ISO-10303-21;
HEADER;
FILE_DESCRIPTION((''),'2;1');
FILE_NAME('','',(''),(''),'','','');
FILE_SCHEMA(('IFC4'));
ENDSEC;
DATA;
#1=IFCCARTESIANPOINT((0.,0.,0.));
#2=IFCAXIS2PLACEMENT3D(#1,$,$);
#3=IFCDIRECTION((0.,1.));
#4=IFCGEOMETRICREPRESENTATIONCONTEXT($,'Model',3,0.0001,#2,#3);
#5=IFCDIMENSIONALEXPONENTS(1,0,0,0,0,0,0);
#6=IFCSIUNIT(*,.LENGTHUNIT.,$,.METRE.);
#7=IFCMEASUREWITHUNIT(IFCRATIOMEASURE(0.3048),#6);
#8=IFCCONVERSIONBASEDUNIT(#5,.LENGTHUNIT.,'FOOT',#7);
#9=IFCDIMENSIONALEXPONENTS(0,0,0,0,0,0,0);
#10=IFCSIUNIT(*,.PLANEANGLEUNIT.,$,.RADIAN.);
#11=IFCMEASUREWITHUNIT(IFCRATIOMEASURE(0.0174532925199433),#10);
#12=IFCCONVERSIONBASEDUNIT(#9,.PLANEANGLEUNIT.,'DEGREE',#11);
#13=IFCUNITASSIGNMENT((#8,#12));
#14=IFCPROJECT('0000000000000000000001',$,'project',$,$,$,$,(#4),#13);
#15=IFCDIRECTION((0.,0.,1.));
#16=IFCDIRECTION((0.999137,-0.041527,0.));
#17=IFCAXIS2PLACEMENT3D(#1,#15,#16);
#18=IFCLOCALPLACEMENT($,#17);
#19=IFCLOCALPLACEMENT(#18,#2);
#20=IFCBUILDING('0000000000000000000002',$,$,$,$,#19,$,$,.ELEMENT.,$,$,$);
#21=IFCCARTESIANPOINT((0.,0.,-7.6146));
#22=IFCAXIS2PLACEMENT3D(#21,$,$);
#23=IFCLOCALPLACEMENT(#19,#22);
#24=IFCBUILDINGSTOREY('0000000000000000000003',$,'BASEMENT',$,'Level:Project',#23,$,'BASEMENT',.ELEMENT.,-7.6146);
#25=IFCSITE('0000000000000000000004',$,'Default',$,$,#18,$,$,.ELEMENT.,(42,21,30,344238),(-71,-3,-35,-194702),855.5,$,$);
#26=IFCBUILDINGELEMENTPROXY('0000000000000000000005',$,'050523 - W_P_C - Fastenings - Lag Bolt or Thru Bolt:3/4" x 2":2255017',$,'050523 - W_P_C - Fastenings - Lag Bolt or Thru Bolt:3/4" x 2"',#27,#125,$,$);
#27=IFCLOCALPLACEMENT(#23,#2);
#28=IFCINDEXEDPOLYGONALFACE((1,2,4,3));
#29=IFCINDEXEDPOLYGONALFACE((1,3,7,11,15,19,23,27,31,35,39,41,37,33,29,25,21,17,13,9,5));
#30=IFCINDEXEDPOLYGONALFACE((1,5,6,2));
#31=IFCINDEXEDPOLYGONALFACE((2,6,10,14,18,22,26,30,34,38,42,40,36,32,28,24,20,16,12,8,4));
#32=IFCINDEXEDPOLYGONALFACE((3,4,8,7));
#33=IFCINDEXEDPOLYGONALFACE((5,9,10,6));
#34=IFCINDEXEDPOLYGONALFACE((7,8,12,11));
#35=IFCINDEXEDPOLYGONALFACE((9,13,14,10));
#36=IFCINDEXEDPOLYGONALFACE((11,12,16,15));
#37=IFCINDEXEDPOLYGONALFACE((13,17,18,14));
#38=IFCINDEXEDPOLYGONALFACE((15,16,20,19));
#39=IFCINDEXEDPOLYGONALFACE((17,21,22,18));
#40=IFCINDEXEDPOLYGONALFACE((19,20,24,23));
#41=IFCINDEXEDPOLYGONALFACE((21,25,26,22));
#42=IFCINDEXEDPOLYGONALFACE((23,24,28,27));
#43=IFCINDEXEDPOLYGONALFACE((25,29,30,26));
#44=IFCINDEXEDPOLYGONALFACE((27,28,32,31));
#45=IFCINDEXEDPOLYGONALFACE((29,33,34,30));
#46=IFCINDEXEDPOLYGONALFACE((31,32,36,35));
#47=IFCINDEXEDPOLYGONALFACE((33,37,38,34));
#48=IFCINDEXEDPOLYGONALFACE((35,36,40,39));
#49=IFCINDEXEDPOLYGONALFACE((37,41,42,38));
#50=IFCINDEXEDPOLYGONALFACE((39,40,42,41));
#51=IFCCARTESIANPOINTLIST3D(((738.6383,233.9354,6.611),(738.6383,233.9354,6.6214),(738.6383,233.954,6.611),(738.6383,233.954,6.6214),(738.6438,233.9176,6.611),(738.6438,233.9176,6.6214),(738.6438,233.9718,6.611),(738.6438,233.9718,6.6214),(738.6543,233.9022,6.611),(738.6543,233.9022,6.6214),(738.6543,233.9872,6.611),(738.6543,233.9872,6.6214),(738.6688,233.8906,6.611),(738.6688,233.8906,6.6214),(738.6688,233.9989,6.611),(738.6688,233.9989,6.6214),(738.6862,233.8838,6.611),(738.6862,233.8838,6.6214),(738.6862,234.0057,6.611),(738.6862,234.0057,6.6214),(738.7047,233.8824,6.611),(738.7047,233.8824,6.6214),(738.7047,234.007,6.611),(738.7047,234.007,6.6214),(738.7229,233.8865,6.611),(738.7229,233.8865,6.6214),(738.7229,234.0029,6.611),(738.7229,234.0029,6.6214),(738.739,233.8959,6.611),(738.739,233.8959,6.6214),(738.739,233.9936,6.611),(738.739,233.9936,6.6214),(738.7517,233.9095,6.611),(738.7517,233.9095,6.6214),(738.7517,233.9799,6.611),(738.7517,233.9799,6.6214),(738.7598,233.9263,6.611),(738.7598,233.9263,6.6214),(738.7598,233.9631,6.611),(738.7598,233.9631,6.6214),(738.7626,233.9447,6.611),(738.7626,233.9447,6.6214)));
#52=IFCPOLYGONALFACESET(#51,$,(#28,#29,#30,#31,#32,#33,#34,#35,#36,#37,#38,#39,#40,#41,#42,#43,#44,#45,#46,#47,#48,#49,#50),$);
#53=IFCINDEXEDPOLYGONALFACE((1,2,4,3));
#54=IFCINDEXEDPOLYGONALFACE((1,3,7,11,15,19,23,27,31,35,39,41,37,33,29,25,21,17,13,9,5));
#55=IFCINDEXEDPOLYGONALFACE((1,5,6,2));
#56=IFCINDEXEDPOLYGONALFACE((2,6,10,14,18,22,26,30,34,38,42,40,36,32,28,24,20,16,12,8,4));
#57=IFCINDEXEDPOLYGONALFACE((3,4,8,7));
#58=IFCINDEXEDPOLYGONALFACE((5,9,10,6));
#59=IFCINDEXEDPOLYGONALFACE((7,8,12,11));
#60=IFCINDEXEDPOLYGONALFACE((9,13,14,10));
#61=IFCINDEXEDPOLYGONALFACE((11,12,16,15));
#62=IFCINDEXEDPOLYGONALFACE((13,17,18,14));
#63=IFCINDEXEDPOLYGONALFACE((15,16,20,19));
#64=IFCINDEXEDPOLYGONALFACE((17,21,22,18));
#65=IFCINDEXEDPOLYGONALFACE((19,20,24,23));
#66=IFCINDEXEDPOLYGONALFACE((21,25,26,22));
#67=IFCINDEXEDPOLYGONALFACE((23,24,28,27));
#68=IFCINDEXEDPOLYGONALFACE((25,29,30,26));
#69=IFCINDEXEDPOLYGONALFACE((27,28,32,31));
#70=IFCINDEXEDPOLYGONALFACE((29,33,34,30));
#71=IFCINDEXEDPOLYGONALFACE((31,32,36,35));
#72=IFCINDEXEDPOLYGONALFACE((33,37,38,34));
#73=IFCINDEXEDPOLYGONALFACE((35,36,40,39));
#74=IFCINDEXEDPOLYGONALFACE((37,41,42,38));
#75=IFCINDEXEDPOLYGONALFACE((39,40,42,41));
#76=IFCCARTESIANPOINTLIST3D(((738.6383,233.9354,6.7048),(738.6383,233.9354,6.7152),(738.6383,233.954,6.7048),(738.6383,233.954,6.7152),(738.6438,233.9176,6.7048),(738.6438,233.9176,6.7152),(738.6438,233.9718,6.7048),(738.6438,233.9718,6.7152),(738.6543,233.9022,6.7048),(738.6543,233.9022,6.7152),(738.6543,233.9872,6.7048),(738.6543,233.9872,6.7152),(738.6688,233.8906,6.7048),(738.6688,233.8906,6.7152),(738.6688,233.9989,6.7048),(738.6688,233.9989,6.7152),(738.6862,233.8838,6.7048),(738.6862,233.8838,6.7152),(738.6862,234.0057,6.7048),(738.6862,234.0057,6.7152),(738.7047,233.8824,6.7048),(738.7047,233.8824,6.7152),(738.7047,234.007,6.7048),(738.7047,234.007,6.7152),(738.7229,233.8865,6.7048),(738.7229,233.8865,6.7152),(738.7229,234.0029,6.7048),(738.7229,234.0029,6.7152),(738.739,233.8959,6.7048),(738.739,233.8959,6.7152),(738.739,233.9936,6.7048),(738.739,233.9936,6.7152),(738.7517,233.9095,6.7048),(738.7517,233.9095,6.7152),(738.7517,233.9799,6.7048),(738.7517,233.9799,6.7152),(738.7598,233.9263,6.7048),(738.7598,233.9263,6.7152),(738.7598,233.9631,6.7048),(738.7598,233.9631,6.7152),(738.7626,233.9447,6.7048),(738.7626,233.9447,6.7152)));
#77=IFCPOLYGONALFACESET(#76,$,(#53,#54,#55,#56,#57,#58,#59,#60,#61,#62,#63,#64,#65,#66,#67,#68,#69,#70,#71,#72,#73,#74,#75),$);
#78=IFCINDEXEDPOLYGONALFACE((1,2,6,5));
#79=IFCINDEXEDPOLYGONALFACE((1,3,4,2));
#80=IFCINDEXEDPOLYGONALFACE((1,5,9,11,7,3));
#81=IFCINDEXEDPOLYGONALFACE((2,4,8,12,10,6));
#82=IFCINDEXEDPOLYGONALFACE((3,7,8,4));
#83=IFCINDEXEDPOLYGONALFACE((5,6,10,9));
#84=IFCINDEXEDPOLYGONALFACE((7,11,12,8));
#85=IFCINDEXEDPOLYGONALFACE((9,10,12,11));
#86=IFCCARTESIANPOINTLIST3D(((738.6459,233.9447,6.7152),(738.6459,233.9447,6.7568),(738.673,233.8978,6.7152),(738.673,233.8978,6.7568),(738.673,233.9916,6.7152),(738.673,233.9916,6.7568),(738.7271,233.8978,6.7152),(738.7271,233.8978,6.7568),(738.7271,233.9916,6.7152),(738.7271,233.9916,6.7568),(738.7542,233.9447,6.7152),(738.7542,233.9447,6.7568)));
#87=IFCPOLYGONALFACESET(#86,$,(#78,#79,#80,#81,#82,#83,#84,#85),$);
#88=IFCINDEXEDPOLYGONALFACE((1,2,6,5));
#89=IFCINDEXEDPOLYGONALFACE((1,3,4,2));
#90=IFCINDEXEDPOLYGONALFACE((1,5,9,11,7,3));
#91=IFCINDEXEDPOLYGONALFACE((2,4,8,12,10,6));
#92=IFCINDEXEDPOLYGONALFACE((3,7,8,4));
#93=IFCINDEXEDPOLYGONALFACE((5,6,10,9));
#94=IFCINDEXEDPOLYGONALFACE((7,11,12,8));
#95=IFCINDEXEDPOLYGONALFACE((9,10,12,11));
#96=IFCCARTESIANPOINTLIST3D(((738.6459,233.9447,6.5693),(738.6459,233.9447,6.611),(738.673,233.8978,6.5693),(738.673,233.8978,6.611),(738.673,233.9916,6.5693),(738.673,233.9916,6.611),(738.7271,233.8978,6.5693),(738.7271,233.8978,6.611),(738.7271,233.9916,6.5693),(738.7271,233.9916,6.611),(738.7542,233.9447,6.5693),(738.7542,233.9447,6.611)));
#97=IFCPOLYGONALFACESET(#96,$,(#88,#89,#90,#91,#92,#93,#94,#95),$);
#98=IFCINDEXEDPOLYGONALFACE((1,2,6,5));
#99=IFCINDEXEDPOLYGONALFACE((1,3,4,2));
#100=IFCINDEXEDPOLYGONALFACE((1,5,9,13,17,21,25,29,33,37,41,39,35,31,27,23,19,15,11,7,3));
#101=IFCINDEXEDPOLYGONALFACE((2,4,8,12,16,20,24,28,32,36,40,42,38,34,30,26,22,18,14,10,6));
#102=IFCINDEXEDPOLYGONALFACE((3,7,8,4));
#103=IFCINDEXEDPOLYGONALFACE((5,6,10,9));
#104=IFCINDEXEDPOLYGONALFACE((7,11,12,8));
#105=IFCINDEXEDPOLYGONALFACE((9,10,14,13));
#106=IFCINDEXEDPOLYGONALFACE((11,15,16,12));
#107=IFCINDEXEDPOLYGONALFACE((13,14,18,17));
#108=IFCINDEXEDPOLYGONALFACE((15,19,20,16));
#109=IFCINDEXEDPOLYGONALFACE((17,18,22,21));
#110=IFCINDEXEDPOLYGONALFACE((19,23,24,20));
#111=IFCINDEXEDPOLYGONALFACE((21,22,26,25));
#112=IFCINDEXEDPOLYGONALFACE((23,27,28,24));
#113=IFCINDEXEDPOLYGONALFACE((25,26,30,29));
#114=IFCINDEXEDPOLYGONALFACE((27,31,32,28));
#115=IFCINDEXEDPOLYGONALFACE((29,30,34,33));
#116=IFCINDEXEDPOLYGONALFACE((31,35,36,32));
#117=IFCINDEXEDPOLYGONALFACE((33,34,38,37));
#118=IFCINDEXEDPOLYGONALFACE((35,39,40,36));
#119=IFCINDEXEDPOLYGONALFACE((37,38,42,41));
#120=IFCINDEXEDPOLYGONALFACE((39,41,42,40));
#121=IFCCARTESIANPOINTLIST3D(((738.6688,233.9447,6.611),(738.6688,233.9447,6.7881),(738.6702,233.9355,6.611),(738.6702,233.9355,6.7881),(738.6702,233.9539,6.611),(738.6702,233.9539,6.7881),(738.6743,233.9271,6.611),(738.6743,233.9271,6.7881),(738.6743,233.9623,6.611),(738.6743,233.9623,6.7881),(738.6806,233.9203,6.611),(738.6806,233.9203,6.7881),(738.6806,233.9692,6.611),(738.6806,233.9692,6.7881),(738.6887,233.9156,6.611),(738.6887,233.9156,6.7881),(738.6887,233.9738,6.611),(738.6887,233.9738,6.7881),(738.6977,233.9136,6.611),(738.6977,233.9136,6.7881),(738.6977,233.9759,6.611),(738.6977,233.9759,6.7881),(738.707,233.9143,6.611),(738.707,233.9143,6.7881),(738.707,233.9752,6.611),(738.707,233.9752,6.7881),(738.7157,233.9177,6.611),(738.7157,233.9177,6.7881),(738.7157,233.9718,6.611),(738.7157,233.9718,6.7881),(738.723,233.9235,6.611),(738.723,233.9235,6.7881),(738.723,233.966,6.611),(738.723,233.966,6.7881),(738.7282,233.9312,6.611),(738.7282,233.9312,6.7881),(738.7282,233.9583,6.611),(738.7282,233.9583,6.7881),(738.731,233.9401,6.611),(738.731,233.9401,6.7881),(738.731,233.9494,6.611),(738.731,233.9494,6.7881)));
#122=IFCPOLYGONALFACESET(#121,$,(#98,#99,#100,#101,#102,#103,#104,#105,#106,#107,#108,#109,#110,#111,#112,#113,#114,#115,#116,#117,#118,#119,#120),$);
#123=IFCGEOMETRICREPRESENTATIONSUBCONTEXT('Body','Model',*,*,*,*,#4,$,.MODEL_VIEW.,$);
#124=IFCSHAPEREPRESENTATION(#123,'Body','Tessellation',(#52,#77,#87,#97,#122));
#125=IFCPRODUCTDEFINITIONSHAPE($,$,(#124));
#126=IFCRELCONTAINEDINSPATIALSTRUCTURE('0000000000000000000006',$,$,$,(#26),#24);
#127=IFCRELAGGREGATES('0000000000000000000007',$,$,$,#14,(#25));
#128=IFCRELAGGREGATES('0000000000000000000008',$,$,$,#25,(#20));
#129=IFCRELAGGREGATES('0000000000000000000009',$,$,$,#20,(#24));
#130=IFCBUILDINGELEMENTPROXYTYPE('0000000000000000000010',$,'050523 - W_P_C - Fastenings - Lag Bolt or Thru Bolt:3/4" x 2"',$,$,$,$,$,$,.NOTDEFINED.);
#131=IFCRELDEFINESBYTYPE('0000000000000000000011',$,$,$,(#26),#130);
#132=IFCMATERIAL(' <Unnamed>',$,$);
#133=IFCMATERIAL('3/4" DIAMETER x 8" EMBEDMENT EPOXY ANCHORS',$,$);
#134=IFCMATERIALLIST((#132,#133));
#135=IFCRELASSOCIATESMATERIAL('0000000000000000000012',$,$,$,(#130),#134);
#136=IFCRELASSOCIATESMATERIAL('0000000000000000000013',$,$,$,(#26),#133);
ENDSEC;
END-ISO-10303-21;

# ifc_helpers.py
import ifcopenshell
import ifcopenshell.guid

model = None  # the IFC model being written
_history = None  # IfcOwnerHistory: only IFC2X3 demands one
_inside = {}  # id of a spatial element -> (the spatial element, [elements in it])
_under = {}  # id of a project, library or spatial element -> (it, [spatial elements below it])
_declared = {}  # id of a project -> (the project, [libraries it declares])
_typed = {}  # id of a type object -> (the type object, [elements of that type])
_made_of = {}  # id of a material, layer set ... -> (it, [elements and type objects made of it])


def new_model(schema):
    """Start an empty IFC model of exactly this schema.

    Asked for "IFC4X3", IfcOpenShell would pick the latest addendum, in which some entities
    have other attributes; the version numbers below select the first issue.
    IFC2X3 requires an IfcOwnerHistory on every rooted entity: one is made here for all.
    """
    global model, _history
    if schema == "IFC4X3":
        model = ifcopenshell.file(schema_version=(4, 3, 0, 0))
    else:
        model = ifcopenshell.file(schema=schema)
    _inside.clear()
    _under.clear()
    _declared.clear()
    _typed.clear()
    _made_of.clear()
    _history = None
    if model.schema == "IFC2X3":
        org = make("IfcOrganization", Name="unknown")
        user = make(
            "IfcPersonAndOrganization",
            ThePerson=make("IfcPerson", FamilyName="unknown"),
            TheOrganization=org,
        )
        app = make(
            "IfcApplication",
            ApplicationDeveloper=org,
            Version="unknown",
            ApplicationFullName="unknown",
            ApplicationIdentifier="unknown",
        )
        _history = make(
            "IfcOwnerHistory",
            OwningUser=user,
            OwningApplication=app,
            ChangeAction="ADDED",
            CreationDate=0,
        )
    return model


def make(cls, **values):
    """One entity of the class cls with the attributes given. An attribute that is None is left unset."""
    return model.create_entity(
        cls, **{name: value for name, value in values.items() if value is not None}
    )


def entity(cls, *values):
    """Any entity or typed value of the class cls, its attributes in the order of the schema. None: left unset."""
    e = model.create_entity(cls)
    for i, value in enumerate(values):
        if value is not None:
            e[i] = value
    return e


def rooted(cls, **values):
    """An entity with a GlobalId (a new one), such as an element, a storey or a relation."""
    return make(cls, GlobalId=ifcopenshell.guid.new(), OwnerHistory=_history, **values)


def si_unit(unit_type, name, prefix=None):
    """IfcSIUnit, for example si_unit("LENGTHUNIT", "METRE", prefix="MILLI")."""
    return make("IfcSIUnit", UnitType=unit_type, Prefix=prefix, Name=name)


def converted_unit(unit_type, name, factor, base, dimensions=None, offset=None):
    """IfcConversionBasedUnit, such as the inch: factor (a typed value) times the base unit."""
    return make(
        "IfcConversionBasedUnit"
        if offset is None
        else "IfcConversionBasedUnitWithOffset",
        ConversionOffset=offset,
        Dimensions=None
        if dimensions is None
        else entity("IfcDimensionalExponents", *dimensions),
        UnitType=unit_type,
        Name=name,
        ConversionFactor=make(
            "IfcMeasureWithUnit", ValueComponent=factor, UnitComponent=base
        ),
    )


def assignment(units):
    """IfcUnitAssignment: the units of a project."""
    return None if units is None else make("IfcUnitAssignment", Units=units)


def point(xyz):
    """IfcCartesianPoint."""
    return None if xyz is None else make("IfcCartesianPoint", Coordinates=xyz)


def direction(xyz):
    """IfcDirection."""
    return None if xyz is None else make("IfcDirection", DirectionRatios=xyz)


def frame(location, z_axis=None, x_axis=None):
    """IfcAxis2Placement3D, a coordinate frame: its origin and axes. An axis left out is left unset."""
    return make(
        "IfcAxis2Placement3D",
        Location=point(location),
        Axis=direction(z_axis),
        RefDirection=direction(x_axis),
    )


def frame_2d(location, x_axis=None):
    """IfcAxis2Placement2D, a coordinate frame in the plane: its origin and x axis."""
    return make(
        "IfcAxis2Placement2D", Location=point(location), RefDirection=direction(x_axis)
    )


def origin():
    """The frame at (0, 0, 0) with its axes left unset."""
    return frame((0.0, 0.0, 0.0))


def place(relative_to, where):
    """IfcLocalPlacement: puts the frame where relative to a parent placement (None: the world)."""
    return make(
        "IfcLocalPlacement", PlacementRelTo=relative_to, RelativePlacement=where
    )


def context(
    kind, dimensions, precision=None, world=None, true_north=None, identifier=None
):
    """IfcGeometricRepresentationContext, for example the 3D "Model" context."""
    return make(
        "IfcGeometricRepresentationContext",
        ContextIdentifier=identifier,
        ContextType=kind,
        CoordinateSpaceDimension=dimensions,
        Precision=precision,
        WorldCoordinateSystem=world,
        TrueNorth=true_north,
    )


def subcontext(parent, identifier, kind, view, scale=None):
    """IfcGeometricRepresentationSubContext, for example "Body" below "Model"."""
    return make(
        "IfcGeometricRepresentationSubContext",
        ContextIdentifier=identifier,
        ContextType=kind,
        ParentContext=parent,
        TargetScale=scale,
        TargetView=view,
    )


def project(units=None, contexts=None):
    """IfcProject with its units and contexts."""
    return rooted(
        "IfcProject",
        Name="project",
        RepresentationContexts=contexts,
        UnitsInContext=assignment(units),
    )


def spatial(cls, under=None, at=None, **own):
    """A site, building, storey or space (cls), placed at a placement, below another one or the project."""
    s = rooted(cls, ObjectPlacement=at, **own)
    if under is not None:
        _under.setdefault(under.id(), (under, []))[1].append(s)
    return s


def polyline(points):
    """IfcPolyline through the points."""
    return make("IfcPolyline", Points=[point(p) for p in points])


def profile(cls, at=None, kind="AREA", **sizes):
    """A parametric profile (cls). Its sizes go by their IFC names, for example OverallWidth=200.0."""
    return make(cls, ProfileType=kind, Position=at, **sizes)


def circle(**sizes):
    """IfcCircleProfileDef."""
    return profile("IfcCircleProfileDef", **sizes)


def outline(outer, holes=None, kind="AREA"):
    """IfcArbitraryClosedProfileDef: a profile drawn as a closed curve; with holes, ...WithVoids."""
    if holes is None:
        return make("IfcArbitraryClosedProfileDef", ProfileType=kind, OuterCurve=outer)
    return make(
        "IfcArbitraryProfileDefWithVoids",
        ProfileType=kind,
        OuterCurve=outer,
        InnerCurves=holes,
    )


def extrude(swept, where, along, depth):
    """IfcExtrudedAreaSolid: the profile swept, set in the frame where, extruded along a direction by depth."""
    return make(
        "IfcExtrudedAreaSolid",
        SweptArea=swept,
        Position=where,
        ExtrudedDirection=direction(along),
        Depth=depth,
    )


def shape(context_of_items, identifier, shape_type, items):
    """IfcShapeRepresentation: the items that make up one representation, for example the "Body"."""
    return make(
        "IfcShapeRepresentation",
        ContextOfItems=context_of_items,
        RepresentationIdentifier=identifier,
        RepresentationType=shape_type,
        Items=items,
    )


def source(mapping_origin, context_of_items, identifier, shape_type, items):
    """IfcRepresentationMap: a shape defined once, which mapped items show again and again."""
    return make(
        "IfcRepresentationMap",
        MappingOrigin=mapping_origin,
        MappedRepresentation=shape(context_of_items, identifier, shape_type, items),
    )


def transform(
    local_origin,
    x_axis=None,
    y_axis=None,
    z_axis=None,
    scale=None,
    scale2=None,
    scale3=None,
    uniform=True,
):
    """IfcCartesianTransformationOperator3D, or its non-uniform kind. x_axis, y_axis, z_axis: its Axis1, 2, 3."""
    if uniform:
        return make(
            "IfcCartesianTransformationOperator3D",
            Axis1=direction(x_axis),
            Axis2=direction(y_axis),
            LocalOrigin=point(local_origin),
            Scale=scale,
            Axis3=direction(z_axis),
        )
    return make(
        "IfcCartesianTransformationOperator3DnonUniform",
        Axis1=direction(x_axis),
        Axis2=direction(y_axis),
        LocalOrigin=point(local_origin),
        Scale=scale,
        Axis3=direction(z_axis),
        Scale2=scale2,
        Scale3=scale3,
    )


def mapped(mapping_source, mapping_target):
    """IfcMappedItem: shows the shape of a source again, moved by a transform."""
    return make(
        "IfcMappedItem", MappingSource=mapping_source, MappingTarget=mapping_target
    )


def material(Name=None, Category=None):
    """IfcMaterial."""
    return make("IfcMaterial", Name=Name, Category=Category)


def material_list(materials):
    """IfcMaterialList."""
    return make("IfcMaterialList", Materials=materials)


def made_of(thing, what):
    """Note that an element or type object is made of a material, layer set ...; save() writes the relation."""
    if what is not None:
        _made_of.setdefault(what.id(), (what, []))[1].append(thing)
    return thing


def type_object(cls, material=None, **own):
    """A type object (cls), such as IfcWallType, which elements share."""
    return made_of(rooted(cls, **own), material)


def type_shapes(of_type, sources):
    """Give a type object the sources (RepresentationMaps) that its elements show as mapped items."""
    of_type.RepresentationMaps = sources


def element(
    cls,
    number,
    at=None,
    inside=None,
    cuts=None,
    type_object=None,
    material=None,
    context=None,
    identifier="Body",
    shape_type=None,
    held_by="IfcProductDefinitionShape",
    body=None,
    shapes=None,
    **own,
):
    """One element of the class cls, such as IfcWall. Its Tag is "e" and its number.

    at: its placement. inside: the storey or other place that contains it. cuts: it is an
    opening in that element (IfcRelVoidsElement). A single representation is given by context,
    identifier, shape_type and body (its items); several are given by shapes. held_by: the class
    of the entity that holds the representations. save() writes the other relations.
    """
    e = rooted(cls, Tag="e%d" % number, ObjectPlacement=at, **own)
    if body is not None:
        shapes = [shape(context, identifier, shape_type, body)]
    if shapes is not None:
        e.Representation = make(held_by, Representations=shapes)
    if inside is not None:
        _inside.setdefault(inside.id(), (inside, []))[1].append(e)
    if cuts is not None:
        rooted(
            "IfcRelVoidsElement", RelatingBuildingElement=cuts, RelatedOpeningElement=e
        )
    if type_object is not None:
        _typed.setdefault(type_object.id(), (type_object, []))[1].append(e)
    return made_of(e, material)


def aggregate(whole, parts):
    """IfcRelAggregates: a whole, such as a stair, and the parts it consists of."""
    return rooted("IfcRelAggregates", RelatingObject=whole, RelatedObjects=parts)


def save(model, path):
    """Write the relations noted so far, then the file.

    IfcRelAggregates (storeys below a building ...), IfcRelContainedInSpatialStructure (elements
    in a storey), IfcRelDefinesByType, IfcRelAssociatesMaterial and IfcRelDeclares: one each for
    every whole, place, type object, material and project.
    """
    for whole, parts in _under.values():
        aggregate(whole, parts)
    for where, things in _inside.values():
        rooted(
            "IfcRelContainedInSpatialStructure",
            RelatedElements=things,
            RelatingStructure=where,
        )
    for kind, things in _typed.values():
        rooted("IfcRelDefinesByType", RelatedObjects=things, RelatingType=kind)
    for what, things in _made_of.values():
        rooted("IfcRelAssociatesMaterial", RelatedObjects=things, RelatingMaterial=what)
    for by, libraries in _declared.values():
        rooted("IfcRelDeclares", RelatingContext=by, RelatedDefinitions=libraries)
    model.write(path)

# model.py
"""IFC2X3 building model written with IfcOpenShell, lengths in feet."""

from ifc_helpers import new_model, entity, si_unit, converted_unit, direction, frame, frame_2d, origin, place, context, subcontext, project, spatial, polyline, circle, outline, extrude, source, transform, mapped, material, material_list, type_object, type_shapes, element, save


model = new_model("IFC2X3")

# Units and contexts
model_context = context("Model", 3, precision=0.0001, world=origin(), true_north=direction((0.0, 1.0)))
body_context = subcontext(model_context, "Body", "Model", "MODEL_VIEW")
ifc_project = project(units=[converted_unit("LENGTHUNIT", "FOOT", entity("IfcRatioMeasure", 0.3048), si_unit("LENGTHUNIT", "METRE"), dimensions=[1, 0, 0, 0, 0, 0, 0]), converted_unit("PLANEANGLEUNIT", "DEGREE", entity("IfcRatioMeasure", 0.0174532925199433), si_unit("PLANEANGLEUNIT", "RADIAN"), dimensions=[0, 0, 0, 0, 0, 0, 0])], contexts=[model_context])

# Site, building, storey
site_placement = place(None, frame((0.0, 0.0, 0.0), z_axis=(0.0, 0.0, 1.0), x_axis=(0.999137, -0.041527, 0.0)))
site = spatial("IfcSite", under=ifc_project, at=site_placement, Name="Default", CompositionType="ELEMENT", RefLatitude=(42, 21, 30, 344238), RefLongitude=(-71, -3, -35, -194702), RefElevation=855.5)
building_placement = place(site_placement, origin())
building = spatial("IfcBuilding", under=site, at=building_placement, CompositionType="ELEMENT")
storey_placement = place(building_placement, frame((0.0, 0.0, -7.6146)))
storey = spatial("IfcBuildingStorey", under=building, at=storey_placement, Name="BASEMENT", ObjectType="Level:Project", LongName="BASEMENT", CompositionType="ELEMENT", Elevation=-7.6146)

# Building element proxy
ifc_material_1 = material(Name=" <Unnamed>")
ifc_material_2 = material(Name="3/4\" DIAMETER x 8\" EMBEDMENT EPOXY ANCHORS")
ifc_material_list_1 = material_list([ifc_material_1, ifc_material_2])
building_element_proxy_type_1 = type_object("IfcBuildingElementProxyType", Name="050523 - W_P_C - Fastenings - Lag Bolt or Thru Bolt:3/4\" x 2\"", PredefinedType="NOTDEFINED", material=ifc_material_list_1)
shared_shape_1 = source(origin(), body_context, "Body", "SweptSolid", [
    extrude(circle(Radius=0.0625, at=frame_2d((0.0, 0.0), x_axis=(1.0, 0.0))), frame((0.0, 0.0, 0.0), z_axis=(0.0, 0.0, 1.0), x_axis=(0.0, -1.0, 0.0)), (0.0, 0.0, 1.0), 0.0104),
    extrude(circle(Radius=0.0625, at=frame_2d((0.0, 0.0), x_axis=(1.0, 0.0))), frame((0.0, 0.0, -0.0938), z_axis=(0.0, 0.0, 1.0), x_axis=(0.0, -1.0, 0.0)), (0.0, 0.0, 1.0), 0.0104),
    extrude(outline(polyline([(-0.0271, -0.0469), (0.0271, -0.0469), (0.0541, 0.0), (0.0271, 0.0469), (-0.0271, 0.0469), (-0.0541, 0.0), (-0.0271, -0.0469)])), frame((0.0, 0.0, -0.1354), z_axis=(0.0, 0.0, 1.0), x_axis=(0.866025, -0.5, 0.0)), (0.0, 0.0, 1.0), 0.0417),
    extrude(outline(polyline([(-0.0271, -0.0469), (0.0271, -0.0469), (0.0541, 0.0), (0.0271, 0.0469), (-0.0271, 0.0469), (-0.0541, 0.0), (-0.0271, -0.0469)])), frame((0.0, 0.0, 0.0104), z_axis=(0.0, 0.0, 1.0), x_axis=(0.0, -1.0, 0.0)), (0.0, 0.0, 1.0), 0.0417),
    extrude(circle(Radius=0.0312, at=frame_2d((0.0, 0.0), x_axis=(1.0, 0.0))), frame((0.0, 0.0, -0.1667), z_axis=(0.0, 0.0, 1.0), x_axis=(0.0, 1.0, 0.0)), (0.0, 0.0, 1.0), 0.1771),
])
type_shapes(building_element_proxy_type_1, [shared_shape_1])
for number, where, z_axis, x_axis, name in (
    (1, (738.7001, 233.9447, 6.6214), (0.0, 0.0, -1.0), (0.0, -1.0, 0.0), "050523 - W_P_C - Fastenings - Lag Bolt or Thru Bolt:3/4\" x 2\":2255017"),
):
    element("IfcBuildingElementProxy", number, at=place(storey_placement, frame(where, z_axis=z_axis, x_axis=x_axis)), inside=storey, type_object=building_element_proxy_type_1, material=ifc_material_2, Name=name, ObjectType="050523 - W_P_C - Fastenings - Lag Bolt or Thru Bolt:3/4\" x 2\"", context=body_context, shape_type="MappedRepresentation", body=[
        mapped(shared_shape_1, transform((0.0, 0.0, 0.0), scale=1.0)),
    ])

save(model, "model.ifc")
